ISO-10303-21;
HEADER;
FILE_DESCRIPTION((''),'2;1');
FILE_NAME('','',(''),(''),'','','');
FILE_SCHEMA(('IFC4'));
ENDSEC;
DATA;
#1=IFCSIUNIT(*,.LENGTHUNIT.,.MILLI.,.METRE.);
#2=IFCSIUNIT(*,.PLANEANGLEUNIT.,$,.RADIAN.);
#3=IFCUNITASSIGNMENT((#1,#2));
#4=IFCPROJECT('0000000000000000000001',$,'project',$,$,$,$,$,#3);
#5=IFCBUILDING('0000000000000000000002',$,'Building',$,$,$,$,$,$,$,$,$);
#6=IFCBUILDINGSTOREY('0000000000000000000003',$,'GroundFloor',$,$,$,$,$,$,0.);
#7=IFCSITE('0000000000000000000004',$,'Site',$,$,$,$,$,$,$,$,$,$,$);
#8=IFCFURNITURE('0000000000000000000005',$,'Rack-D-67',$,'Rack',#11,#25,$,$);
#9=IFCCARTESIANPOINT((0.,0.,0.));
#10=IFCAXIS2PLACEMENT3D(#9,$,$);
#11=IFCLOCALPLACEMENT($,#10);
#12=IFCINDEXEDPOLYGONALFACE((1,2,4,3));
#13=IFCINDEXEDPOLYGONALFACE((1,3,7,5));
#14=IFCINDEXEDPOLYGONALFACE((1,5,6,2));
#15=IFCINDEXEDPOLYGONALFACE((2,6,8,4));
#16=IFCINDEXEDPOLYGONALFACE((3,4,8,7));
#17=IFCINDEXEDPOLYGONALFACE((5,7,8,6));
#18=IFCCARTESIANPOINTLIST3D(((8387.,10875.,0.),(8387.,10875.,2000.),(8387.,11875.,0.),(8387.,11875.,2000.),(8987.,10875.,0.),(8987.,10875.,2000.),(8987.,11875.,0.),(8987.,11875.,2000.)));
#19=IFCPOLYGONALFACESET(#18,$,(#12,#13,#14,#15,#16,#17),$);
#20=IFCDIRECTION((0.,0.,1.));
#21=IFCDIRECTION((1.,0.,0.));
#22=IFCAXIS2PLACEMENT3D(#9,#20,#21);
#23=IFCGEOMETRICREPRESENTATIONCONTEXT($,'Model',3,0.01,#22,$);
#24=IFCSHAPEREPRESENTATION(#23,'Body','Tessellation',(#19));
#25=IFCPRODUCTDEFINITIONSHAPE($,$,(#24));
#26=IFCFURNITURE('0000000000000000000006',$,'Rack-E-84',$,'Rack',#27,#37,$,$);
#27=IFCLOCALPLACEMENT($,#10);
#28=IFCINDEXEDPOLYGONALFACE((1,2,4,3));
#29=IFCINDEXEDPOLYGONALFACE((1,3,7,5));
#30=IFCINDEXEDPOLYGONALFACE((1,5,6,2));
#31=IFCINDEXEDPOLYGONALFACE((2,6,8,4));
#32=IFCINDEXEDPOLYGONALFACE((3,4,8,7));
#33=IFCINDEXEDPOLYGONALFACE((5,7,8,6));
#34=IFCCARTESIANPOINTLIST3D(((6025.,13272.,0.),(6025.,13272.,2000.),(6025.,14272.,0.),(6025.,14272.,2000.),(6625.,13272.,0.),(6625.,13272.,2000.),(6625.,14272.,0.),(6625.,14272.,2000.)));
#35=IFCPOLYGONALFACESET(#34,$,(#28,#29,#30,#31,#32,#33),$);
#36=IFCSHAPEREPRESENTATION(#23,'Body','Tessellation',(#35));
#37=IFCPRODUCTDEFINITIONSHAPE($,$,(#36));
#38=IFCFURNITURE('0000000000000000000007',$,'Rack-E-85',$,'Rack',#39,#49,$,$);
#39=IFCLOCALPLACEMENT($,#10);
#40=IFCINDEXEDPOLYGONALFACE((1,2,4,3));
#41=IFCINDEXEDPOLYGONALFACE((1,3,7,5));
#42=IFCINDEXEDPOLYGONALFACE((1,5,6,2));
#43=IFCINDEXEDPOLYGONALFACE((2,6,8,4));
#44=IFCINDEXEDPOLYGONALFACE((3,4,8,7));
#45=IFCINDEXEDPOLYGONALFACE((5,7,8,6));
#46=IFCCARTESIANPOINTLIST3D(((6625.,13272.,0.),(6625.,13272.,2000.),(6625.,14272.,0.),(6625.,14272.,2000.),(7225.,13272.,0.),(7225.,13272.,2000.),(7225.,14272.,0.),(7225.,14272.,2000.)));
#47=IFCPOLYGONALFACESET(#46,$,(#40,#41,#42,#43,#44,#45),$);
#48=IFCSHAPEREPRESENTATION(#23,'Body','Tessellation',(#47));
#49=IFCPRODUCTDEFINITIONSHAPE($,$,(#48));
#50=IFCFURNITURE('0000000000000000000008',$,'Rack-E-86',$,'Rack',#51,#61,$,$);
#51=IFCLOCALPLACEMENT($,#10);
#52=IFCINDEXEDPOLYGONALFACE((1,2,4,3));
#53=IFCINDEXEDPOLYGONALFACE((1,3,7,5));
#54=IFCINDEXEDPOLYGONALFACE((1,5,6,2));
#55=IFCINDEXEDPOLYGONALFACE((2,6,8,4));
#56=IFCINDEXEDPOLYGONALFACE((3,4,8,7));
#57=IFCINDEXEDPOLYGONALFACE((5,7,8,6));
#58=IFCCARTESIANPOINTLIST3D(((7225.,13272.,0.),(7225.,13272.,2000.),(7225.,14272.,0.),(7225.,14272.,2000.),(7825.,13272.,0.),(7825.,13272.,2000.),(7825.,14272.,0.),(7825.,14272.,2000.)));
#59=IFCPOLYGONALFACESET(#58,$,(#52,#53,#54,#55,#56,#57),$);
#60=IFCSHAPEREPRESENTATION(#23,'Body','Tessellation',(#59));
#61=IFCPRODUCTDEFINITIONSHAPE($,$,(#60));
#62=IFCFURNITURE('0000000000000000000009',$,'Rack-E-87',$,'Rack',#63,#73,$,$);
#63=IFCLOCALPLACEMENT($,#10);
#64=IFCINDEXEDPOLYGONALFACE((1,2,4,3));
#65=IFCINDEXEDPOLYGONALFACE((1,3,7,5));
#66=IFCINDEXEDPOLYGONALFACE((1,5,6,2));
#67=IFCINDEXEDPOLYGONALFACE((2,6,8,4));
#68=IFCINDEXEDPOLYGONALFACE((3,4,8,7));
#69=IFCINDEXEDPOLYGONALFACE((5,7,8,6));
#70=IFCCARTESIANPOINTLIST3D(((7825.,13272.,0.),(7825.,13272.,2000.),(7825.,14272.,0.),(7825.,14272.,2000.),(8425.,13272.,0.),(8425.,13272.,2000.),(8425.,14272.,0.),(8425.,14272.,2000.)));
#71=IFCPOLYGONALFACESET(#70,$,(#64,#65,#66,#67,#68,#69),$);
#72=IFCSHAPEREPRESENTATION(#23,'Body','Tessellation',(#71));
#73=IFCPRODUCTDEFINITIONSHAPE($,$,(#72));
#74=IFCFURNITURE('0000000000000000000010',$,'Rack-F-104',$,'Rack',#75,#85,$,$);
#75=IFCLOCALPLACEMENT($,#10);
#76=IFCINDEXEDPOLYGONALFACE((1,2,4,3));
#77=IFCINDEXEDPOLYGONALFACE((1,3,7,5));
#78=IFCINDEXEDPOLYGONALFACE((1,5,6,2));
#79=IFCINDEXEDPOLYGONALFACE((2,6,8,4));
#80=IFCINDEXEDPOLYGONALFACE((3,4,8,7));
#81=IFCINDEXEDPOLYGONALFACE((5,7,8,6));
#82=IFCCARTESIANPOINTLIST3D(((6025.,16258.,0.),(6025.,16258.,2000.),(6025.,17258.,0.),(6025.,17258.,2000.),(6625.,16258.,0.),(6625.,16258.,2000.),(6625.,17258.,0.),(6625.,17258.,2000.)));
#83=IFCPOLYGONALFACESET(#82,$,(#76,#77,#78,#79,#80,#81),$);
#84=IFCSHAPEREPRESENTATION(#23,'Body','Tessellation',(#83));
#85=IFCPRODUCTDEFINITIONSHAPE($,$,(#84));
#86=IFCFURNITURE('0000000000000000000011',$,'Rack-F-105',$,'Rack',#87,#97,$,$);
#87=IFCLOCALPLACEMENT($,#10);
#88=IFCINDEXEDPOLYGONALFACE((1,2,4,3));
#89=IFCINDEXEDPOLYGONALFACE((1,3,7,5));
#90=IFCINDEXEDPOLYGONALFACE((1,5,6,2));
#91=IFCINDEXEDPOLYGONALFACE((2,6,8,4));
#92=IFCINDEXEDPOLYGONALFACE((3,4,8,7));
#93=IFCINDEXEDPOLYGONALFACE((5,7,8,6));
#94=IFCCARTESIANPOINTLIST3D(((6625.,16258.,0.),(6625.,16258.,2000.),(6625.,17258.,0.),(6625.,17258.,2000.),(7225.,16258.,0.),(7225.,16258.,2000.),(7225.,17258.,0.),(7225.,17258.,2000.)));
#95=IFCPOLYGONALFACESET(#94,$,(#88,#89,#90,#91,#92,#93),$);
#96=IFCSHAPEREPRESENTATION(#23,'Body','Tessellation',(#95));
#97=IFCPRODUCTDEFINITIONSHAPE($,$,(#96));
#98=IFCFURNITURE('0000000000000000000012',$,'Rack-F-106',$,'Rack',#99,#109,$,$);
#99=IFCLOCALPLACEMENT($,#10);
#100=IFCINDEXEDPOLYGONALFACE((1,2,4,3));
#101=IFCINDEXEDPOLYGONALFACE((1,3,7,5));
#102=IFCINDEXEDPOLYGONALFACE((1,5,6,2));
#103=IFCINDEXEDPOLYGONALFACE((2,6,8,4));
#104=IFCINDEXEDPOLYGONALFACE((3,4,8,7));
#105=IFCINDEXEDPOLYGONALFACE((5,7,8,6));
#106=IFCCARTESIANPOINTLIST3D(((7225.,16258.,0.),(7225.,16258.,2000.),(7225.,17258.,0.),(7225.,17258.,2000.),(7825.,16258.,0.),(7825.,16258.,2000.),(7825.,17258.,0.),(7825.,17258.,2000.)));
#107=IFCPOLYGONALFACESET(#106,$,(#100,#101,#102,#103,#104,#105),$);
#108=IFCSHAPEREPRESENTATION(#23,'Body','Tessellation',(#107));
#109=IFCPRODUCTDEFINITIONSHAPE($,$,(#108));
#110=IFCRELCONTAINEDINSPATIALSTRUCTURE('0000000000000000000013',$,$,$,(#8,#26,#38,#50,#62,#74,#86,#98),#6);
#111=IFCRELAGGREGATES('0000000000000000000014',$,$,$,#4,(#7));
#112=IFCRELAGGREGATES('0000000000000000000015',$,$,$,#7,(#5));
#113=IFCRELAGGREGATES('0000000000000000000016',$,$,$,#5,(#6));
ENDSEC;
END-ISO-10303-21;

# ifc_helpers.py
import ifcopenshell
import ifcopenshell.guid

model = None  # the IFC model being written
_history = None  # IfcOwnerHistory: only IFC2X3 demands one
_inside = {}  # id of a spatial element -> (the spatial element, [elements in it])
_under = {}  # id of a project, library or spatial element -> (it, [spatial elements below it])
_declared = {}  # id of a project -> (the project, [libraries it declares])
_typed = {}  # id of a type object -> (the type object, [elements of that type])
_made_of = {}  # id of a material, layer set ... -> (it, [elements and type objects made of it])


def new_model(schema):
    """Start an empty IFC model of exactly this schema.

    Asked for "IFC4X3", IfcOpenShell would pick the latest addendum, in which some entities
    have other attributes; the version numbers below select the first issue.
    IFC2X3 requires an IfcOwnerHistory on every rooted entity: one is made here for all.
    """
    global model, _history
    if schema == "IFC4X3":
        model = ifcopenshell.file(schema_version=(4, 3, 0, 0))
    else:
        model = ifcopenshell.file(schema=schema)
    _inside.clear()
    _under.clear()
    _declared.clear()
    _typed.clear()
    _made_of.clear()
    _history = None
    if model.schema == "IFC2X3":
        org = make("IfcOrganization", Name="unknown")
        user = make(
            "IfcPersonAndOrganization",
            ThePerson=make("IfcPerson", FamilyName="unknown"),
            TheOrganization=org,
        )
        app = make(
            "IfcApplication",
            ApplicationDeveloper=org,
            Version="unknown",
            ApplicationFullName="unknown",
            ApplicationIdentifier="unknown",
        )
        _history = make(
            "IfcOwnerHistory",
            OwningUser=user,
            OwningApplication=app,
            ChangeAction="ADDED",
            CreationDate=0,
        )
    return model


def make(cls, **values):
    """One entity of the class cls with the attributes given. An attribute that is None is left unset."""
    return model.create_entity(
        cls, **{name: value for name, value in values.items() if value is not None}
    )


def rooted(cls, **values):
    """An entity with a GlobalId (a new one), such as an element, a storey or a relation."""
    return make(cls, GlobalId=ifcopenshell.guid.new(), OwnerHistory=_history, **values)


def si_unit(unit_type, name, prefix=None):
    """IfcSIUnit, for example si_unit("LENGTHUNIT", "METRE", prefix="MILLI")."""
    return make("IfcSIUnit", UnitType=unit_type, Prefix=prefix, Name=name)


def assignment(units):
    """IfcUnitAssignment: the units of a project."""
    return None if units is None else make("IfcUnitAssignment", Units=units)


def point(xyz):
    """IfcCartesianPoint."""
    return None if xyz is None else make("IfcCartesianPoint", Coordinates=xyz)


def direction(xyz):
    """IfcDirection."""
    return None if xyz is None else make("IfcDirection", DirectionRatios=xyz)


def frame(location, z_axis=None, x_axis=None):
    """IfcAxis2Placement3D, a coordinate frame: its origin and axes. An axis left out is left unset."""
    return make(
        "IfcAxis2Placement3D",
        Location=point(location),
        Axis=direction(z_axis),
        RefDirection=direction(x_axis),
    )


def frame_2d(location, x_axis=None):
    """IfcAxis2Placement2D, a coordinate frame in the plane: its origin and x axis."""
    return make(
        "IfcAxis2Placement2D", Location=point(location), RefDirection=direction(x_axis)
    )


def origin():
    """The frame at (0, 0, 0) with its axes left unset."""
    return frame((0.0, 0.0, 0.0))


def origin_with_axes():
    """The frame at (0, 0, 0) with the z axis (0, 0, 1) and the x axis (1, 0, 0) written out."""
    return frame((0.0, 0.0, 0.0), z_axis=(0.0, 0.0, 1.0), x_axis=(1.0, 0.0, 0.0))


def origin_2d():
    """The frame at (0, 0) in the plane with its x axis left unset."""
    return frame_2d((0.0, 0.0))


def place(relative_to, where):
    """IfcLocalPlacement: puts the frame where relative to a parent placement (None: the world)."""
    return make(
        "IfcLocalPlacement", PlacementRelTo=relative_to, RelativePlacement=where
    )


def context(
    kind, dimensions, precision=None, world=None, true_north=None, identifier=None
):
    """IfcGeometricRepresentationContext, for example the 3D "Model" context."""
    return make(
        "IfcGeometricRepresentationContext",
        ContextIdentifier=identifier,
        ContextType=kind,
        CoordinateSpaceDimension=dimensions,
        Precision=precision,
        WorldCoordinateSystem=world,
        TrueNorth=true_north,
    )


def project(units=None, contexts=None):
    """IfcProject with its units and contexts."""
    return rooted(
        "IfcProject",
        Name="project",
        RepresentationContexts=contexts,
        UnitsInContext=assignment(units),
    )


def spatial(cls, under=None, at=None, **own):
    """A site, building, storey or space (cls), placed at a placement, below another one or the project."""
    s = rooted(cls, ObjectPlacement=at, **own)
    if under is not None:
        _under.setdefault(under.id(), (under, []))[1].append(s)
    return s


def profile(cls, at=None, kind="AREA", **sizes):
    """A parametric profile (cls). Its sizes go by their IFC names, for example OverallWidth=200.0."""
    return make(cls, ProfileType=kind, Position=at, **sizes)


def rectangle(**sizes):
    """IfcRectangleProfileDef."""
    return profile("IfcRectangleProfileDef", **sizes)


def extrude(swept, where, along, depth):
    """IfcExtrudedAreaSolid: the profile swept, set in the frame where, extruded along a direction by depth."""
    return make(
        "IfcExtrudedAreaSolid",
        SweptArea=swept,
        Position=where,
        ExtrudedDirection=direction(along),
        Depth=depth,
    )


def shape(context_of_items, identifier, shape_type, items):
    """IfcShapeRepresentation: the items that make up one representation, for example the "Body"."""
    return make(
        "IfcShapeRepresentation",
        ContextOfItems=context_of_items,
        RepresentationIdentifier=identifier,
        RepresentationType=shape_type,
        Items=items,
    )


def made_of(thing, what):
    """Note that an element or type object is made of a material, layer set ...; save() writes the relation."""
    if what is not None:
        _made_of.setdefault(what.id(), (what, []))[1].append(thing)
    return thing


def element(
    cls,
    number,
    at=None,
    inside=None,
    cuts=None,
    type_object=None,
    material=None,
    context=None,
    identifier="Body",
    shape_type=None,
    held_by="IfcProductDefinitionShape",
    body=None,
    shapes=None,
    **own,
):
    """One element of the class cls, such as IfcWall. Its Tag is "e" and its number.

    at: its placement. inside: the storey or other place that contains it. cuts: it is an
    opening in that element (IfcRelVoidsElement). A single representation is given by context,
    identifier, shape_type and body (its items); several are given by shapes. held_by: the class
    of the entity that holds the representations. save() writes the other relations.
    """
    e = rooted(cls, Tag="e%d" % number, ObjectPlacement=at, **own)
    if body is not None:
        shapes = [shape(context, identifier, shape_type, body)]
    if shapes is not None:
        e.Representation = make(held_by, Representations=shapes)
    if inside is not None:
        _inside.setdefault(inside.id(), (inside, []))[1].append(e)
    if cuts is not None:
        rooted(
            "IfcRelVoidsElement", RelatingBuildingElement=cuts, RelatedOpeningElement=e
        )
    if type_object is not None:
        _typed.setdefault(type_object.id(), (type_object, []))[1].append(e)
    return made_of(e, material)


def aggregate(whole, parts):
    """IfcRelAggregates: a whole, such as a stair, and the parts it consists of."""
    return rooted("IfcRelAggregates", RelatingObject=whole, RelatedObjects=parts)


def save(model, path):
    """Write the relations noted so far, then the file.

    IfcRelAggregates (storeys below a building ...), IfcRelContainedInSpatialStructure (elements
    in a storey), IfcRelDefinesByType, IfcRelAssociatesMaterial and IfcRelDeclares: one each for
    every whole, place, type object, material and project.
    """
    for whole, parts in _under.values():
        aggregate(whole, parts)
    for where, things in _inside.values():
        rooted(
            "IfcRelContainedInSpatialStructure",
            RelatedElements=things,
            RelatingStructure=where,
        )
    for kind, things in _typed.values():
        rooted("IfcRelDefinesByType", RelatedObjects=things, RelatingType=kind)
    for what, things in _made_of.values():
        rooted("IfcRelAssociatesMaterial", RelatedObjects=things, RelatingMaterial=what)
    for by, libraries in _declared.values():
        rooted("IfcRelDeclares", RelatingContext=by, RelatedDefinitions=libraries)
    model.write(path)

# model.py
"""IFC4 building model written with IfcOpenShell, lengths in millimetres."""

from ifc_helpers import new_model, si_unit, frame, origin, origin_with_axes, origin_2d, place, context, project, spatial, rectangle, extrude, element, save


model = new_model("IFC4")

# Units and contexts
model_context = context("Model", 3, precision=0.01, world=origin_with_axes())
ifc_project = project(units=[si_unit("LENGTHUNIT", "METRE", prefix="MILLI"), si_unit("PLANEANGLEUNIT", "RADIAN")])

# Site, building, storey
site = spatial("IfcSite", under=ifc_project, Name="Site")
building = spatial("IfcBuilding", under=site, Name="Building")
storey = spatial("IfcBuildingStorey", under=building, Name="GroundFloor", Elevation=0.0)

# Furniture
for number, where, z_axis, x_axis, name in (
    (1, (8687.0, 11375.0, 0.0), (0.0, 0.0, 1.0), (1.0, 0.0, 0.0), "Rack-D-67"),
    (2, (6325.0, 13772.0, 0.0), (0.0, 0.0, 1.0), (1.0, 0.0, 0.0), "Rack-E-84"),
    (3, (6925.0, 13772.0, 0.0), (0.0, 0.0, 1.0), (1.0, 0.0, 0.0), "Rack-E-85"),
    (4, (7525.0, 13772.0, 0.0), (0.0, 0.0, 1.0), (1.0, 0.0, 0.0), "Rack-E-86"),
    (5, (8125.0, 13772.0, 0.0), (0.0, 0.0, 1.0), (1.0, 0.0, 0.0), "Rack-E-87"),
    (6, (6325.0, 16758.0, 0.0), (0.0, 0.0, 1.0), (1.0, 0.0, 0.0), "Rack-F-104"),
    (7, (6925.0, 16758.0, 0.0), (0.0, 0.0, 1.0), (1.0, 0.0, 0.0), "Rack-F-105"),
    (8, (7525.0, 16758.0, 0.0), (0.0, 0.0, 1.0), (1.0, 0.0, 0.0), "Rack-F-106"),
):
    element("IfcFurniture", number, at=place(None, frame(where, z_axis=z_axis, x_axis=x_axis)), inside=storey, Name=name, ObjectType="Rack", context=model_context, shape_type="SweptSolid", body=[
        extrude(rectangle(XDim=600.0, YDim=1000.0, at=origin_2d()), origin(), (0.0, 0.0, 1.0), 2000.0),
    ])

save(model, "model.ifc")
